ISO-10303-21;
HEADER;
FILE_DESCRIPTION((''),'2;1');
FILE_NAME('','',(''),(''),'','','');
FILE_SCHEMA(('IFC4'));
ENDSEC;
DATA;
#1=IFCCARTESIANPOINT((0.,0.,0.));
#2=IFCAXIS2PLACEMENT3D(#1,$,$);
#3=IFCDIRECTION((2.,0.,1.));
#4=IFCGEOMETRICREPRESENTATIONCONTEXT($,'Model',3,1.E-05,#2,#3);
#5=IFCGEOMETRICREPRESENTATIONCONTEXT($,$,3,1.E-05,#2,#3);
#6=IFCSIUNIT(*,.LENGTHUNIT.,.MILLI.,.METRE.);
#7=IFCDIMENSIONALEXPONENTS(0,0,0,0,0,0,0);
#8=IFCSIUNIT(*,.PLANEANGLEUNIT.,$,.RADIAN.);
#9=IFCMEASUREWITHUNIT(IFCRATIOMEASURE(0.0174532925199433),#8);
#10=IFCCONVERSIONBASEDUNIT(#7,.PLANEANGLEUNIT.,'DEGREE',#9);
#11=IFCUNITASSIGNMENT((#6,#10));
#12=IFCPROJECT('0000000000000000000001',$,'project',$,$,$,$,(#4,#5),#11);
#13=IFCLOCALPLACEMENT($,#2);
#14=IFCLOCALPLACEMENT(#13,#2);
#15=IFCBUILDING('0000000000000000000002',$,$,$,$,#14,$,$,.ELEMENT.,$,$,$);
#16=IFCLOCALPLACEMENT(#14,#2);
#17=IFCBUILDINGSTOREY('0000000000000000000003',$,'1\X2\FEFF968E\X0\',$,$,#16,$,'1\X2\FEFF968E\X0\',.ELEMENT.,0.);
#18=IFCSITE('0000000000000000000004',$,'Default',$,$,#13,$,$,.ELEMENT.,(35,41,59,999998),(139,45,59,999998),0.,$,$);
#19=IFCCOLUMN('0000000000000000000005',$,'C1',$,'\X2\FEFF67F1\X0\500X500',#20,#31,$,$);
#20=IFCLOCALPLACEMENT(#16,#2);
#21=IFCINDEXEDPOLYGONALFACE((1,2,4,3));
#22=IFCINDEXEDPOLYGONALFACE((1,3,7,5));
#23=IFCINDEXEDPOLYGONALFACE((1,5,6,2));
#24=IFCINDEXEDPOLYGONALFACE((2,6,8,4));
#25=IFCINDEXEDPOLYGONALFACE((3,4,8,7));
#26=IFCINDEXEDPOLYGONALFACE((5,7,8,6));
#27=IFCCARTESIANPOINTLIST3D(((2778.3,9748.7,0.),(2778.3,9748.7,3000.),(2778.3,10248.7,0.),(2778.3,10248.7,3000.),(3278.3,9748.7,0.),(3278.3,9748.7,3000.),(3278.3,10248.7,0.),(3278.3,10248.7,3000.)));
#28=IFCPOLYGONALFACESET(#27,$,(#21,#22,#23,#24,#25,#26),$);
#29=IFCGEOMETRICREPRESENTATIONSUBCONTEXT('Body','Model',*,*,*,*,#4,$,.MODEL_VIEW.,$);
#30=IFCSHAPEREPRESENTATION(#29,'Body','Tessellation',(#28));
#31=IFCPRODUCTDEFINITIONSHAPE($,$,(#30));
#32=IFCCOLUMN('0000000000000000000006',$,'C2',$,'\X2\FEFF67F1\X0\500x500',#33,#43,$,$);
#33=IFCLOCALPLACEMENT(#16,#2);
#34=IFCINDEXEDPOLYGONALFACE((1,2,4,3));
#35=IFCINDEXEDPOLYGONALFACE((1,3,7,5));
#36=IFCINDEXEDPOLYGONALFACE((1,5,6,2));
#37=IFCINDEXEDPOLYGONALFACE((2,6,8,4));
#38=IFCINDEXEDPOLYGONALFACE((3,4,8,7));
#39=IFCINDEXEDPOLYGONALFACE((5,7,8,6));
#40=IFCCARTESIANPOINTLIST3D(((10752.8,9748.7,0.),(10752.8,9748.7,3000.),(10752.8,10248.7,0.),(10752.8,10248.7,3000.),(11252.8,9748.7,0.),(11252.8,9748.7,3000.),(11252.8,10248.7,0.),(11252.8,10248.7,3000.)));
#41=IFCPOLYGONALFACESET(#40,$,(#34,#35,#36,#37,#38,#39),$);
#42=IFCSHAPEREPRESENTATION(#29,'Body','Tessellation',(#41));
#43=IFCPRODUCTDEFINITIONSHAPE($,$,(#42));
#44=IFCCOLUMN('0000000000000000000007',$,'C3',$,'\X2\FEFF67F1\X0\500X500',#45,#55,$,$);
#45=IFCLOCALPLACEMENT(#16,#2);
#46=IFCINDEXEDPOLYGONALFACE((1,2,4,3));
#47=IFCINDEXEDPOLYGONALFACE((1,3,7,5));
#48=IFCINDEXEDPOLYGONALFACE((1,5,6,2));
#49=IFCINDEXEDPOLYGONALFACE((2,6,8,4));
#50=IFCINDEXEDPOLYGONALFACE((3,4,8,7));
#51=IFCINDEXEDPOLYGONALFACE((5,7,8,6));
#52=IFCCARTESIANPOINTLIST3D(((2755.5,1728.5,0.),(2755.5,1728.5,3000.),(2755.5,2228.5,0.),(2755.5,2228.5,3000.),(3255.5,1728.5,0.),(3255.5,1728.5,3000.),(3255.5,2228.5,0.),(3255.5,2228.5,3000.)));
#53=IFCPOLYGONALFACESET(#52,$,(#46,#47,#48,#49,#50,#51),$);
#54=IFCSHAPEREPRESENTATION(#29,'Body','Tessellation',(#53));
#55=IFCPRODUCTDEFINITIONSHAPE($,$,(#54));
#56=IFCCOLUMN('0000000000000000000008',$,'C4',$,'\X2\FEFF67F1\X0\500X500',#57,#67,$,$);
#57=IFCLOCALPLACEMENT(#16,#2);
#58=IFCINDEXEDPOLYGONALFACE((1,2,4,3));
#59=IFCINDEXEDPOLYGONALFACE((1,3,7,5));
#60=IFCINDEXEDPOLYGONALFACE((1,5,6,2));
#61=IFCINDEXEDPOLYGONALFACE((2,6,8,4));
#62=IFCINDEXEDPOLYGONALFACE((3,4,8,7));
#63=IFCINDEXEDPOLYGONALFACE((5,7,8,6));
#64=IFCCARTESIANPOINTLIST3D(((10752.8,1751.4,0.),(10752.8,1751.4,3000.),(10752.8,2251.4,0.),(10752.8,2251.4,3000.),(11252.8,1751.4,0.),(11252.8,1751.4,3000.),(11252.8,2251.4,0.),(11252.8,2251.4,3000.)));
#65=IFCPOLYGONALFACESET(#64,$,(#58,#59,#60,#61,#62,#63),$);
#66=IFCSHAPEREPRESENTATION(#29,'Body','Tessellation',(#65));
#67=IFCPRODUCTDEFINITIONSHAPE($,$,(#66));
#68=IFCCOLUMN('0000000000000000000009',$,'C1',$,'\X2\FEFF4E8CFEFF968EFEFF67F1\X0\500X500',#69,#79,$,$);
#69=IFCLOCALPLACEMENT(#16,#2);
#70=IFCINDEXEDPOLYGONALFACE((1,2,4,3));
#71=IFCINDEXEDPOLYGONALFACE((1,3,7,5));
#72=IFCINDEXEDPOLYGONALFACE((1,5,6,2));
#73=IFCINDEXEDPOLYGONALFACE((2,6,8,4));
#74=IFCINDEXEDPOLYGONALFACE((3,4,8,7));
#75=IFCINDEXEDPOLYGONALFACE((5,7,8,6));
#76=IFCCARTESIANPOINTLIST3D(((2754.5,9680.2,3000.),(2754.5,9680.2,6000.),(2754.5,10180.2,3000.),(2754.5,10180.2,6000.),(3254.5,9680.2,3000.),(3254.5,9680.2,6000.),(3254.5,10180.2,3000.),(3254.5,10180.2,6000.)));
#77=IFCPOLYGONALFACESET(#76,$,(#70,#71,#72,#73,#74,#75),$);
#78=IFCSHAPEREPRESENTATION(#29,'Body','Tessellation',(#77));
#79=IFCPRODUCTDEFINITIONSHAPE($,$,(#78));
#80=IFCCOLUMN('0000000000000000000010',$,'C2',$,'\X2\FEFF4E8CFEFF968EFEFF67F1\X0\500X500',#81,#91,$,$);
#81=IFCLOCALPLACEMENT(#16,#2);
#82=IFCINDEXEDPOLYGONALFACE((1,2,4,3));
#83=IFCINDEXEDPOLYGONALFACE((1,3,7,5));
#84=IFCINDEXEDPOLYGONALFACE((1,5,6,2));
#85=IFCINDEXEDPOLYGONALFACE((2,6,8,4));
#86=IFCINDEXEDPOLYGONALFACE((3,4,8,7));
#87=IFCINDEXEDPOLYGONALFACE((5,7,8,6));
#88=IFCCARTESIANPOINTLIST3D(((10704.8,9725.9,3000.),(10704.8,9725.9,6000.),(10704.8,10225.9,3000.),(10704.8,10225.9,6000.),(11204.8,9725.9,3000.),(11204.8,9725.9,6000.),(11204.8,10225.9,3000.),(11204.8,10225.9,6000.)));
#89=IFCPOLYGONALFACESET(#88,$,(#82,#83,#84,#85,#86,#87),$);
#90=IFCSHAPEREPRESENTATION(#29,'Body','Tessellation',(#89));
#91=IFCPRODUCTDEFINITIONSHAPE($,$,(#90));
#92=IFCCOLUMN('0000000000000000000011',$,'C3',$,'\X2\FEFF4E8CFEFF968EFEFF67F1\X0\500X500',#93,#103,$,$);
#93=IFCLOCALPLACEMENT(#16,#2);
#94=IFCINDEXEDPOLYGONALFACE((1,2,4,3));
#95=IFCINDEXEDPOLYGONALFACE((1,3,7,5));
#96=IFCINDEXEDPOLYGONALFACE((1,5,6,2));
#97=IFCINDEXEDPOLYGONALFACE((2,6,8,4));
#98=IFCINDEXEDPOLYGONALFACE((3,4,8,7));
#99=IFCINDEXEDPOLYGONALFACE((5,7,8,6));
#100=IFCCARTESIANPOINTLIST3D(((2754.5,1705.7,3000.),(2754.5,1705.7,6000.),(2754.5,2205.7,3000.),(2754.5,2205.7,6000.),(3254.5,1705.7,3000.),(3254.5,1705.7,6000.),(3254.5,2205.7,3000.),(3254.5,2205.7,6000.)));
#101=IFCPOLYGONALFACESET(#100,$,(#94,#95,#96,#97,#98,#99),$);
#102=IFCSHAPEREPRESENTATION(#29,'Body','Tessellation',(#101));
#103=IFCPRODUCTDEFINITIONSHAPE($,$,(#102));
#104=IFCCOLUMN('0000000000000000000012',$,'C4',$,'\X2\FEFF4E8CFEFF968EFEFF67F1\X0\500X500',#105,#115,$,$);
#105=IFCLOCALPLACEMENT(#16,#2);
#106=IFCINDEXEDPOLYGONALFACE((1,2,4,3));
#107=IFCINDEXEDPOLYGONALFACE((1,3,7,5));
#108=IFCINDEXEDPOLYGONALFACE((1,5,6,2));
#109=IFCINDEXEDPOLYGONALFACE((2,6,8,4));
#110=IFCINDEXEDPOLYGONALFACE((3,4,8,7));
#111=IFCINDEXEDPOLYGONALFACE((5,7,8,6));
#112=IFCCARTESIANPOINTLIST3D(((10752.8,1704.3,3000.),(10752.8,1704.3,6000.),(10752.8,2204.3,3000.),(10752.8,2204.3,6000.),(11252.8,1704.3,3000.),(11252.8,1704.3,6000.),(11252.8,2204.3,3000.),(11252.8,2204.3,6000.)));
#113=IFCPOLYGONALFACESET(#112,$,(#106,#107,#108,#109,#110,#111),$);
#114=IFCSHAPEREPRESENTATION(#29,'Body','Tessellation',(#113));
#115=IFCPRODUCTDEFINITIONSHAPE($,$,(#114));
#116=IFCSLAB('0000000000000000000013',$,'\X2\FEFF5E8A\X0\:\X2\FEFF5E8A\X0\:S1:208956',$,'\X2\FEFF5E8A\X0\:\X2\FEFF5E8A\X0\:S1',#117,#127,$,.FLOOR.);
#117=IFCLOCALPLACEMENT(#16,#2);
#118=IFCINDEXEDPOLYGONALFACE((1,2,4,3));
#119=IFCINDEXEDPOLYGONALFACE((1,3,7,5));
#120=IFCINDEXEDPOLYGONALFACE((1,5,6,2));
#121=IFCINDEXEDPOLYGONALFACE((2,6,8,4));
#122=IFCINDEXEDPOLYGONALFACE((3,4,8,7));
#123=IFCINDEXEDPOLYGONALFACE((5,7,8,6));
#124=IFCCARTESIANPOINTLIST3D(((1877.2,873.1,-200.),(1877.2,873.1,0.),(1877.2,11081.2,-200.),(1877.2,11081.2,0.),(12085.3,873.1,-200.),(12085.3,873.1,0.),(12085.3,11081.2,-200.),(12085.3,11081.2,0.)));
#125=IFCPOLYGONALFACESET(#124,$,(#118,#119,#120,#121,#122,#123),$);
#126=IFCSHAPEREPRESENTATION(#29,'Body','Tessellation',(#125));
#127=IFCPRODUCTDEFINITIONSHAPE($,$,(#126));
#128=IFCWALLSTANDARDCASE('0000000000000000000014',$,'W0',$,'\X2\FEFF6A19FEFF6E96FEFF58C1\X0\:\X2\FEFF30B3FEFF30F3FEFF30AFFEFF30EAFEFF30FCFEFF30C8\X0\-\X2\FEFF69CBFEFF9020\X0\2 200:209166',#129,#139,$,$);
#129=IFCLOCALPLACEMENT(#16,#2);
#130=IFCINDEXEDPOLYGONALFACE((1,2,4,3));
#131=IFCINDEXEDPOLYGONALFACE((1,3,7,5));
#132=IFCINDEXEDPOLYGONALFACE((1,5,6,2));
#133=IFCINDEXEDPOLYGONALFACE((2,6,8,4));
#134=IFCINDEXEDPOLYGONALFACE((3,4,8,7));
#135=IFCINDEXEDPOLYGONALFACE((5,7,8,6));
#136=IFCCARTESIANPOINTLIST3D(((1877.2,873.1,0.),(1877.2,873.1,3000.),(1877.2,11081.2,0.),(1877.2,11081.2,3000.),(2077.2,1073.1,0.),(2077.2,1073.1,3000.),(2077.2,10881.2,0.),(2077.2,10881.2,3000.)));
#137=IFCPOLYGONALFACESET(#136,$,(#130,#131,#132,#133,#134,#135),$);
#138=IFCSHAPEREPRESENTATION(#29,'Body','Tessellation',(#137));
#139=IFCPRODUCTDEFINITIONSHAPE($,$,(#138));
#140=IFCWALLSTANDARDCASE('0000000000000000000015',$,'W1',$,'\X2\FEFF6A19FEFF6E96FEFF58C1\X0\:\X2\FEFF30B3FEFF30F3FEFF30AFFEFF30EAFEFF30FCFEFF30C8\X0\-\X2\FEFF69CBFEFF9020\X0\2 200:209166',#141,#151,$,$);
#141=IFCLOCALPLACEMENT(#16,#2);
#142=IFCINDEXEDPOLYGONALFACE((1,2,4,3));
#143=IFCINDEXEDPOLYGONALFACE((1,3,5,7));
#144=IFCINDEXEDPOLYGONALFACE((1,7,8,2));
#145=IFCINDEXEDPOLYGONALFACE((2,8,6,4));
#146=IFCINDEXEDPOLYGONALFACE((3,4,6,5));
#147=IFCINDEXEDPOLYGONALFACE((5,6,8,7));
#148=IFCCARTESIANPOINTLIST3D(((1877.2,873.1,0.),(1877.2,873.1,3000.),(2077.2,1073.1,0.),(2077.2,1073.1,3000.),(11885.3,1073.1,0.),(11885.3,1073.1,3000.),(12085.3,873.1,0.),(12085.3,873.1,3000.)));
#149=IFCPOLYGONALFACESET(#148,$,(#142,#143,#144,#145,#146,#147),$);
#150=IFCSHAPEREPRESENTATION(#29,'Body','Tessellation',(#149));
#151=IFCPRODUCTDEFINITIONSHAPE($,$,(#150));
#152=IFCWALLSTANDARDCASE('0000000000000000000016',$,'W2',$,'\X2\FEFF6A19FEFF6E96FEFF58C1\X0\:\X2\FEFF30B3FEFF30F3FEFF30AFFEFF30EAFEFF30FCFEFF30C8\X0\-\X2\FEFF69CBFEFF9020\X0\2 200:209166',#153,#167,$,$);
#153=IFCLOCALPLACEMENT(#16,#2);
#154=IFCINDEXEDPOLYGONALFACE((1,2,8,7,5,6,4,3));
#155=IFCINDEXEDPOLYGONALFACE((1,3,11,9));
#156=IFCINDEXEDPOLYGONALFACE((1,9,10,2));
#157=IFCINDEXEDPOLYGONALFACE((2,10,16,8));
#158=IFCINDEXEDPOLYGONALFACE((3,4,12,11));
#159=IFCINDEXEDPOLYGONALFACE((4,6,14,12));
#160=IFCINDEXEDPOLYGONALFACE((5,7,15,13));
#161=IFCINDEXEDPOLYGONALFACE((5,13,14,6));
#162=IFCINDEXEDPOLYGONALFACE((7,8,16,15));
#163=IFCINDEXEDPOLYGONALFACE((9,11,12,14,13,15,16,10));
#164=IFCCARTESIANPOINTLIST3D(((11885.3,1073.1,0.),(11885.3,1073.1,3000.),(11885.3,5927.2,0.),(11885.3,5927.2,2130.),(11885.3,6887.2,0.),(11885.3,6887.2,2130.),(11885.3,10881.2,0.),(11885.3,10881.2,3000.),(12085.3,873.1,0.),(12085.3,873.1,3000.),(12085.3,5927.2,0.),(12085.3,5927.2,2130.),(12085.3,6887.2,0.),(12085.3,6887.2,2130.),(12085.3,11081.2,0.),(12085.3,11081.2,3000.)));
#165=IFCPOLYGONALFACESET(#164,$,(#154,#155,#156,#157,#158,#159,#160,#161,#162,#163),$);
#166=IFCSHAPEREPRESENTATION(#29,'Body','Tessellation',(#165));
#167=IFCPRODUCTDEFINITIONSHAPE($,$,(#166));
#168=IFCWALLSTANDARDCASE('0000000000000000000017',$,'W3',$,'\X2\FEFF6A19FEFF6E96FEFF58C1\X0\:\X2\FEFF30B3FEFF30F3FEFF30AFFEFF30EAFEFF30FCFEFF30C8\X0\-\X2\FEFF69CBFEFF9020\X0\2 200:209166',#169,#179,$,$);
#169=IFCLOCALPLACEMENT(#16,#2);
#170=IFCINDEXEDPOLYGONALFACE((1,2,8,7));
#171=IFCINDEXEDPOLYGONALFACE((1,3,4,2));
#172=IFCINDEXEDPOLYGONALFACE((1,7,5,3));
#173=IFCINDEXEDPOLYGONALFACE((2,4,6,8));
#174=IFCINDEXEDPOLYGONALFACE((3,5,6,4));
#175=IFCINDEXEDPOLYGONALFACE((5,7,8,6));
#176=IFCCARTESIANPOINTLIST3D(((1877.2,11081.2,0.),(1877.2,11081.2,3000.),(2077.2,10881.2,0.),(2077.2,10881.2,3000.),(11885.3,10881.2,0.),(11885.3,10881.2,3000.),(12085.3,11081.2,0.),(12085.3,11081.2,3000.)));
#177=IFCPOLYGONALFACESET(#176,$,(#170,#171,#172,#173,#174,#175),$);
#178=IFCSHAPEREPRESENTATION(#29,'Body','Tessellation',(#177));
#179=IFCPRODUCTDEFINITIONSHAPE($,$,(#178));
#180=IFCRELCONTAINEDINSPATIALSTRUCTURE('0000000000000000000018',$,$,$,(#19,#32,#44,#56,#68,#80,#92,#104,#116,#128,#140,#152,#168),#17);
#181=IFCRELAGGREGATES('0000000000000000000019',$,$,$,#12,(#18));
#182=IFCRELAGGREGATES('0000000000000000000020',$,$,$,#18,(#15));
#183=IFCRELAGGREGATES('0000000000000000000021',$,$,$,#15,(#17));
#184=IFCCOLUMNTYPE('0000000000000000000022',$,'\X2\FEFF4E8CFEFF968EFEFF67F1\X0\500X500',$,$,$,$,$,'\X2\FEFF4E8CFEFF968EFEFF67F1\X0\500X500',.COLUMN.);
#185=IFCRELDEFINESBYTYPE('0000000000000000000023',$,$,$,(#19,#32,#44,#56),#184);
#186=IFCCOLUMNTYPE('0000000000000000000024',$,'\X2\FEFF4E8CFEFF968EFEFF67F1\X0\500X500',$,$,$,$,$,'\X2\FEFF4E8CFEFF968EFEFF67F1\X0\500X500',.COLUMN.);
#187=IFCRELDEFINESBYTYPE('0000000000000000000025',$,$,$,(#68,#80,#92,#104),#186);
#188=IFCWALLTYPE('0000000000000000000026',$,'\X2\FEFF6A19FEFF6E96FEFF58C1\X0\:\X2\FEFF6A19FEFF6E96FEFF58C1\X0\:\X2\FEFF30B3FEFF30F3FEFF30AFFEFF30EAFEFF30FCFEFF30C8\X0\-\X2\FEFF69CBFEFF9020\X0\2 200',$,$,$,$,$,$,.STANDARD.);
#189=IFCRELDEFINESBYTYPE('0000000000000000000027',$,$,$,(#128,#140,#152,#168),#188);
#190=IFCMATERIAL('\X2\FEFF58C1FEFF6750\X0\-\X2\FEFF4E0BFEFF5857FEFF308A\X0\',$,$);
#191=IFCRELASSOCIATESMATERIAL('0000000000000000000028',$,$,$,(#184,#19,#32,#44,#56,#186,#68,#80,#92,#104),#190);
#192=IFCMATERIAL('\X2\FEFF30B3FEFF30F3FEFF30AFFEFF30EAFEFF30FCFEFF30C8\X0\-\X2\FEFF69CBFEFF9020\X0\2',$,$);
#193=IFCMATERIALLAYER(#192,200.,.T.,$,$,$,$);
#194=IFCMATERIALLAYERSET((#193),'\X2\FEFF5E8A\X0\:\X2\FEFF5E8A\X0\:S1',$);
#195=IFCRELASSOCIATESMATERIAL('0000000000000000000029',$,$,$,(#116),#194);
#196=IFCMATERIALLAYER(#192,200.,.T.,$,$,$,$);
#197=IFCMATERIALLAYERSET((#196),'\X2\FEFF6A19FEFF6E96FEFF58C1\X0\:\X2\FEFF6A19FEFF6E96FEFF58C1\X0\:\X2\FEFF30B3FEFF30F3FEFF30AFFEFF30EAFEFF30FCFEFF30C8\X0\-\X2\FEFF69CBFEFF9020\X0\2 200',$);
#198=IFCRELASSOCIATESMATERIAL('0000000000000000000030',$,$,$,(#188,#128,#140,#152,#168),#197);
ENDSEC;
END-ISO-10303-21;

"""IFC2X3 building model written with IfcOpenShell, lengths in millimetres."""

from ifc_helpers import new_model, entity, si_unit, converted_unit, direction, frame, frame_2d, origin, origin_2d_with_axis, place, context, subcontext, project, spatial, polyline, rectangle, outline, extrude, source, transform, mapped, material, layer, layer_set, layer_usage, type_object, type_shapes, element, save


model = new_model("IFC2X3")

# Units and contexts
model_context = context("Model", 3, precision=1e-05, world=origin(), true_north=direction((2.0, 0.0, 1.0)))
context_of_model = context(None, 3, precision=1e-05, world=origin(), true_north=direction((2.0, 0.0, 1.0)))
body_context = subcontext(model_context, "Body", "Model", "MODEL_VIEW")
ifc_project = project(units=[si_unit("LENGTHUNIT", "METRE", prefix="MILLI"), converted_unit("PLANEANGLEUNIT", "DEGREE", entity("IfcRatioMeasure", 0.0174532925199433), si_unit("PLANEANGLEUNIT", "RADIAN"), dimensions=[0, 0, 0, 0, 0, 0, 0])], contexts=[model_context, context_of_model])

# Site, building, storey
site_placement = place(None, origin())
site = spatial("IfcSite", under=ifc_project, at=site_placement, Name="Default", CompositionType="ELEMENT", RefLatitude=(35, 41, 59, 999998), RefLongitude=(139, 45, 59, 999998), RefElevation=0.0)
building_placement = place(site_placement, origin())
building = spatial("IfcBuilding", under=site, at=building_placement, CompositionType="ELEMENT")
storey_placement = place(building_placement, origin())
storey = spatial("IfcBuildingStorey", under=building, at=storey_placement, Name="1\ufeff階", LongName="1\ufeff階", CompositionType="ELEMENT", Elevation=0.0)

# Columns
ifc_material_1 = material(Name="\ufeff壁\ufeff材-\ufeff下\ufeff塗\ufeffり")
column_type_1 = type_object("IfcColumnType", Name="\ufeff二\ufeff階\ufeff柱500X500", ElementType="\ufeff二\ufeff階\ufeff柱500X500", PredefinedType="COLUMN", material=ifc_material_1)
shared_shape_1 = source(origin(), body_context, "Body", "SweptSolid", [
    extrude(rectangle(XDim=500.0, YDim=500.0, at=origin_2d_with_axis()), origin(), (0.0, 0.0, 1.0), 3000.0),
])
type_shapes(column_type_1, [shared_shape_1])
column_1_placement = place(storey_placement, frame((3028.3, 9998.7, 0.0)))
element("IfcColumn", 1, at=column_1_placement, inside=storey, type_object=column_type_1, material=ifc_material_1, Name="C1", ObjectType="\ufeff柱500X500", context=body_context, shape_type="MappedRepresentation", body=[
    mapped(shared_shape_1, transform((0.0, 0.0, 0.0), scale=1.0)),
])
column_2_placement = place(storey_placement, frame((11002.8, 9998.7, 0.0)))
element("IfcColumn", 2, at=column_2_placement, inside=storey, type_object=column_type_1, material=ifc_material_1, Name="C2", ObjectType="\ufeff柱500x500", context=body_context, shape_type="MappedRepresentation", body=[
    mapped(shared_shape_1, transform((0.0, 0.0, 0.0), scale=1.0)),
])
for number, where, name in (
    (3, (3005.5, 1978.5, 0.0), "C3"),
    (4, (11002.8, 2001.4, 0.0), "C4"),
):
    element("IfcColumn", number, at=place(storey_placement, frame(where)), inside=storey, type_object=column_type_1, material=ifc_material_1, Name=name, ObjectType="\ufeff柱500X500", context=body_context, shape_type="MappedRepresentation", body=[
        mapped(shared_shape_1, transform((0.0, 0.0, 0.0), scale=1.0)),
    ])
column_type_2 = type_object("IfcColumnType", Name="\ufeff二\ufeff階\ufeff柱500X500", ElementType="\ufeff二\ufeff階\ufeff柱500X500", PredefinedType="COLUMN", material=ifc_material_1)
shared_shape_2 = source(origin(), body_context, "Body", "SweptSolid", [
    extrude(rectangle(XDim=500.0, YDim=500.0, at=origin_2d_with_axis()), origin(), (0.0, 0.0, 1.0), 3000.0),
])
type_shapes(column_type_2, [shared_shape_2])
for number, where, name in (
    (5, (3004.5, 9930.2, 3000.0), "C1"),
    (6, (10954.8, 9975.9, 3000.0), "C2"),
    (7, (3004.5, 1955.7, 3000.0), "C3"),
    (8, (11002.8, 1954.3, 3000.0), "C4"),
):
    element("IfcColumn", number, at=place(storey_placement, frame(where)), inside=storey, type_object=column_type_2, material=ifc_material_1, Name=name, ObjectType="\ufeff二\ufeff階\ufeff柱500X500", context=body_context, shape_type="MappedRepresentation", body=[
        mapped(shared_shape_2, transform((0.0, 0.0, 0.0), scale=1.0)),
    ])

# Slab
ifc_material_2 = material(Name="\ufeffコ\ufeffン\ufeffク\ufeffリ\ufeffー\ufeffト-\ufeff構\ufeff造2")
ifc_layer_1 = layer(ifc_material_2, 200.0, ventilated=True)
ifc_layer_set_1 = layer_set([ifc_layer_1], Name="\ufeff床:\ufeff床:S1")
ifc_layer_usage_1 = layer_usage(ifc_layer_set_1, "AXIS3", "POSITIVE", 0.0)
slab_placement = place(storey_placement, origin())
element("IfcSlab", 9, at=slab_placement, inside=storey, material=ifc_layer_usage_1, Name="\ufeff床:\ufeff床:S1:208956", ObjectType="\ufeff床:\ufeff床:S1", PredefinedType="FLOOR", context=body_context, shape_type="SweptSolid", body=[
    extrude(rectangle(XDim=10208.1, YDim=10208.1, at=origin_2d_with_axis()), frame((6981.3, 5977.2, 0.0), z_axis=(0.0, 0.0, -1.0), x_axis=(0.0, 1.0, 0.0)), (0.0, 0.0, 1.0), 200.0),
])

# Walls
ifc_layer_2 = layer(ifc_material_2, 200.0, ventilated=True)
ifc_layer_set_2 = layer_set([ifc_layer_2], Name="\ufeff標\ufeff準\ufeff壁:\ufeff標\ufeff準\ufeff壁:\ufeffコ\ufeffン\ufeffク\ufeffリ\ufeffー\ufeffト-\ufeff構\ufeff造2 200")
ifc_layer_usage_2 = layer_usage(ifc_layer_set_2, "AXIS2", "NEGATIVE", 100.0)
wall_type = type_object("IfcWallType", Name="\ufeff標\ufeff準\ufeff壁:\ufeff標\ufeff準\ufeff壁:\ufeffコ\ufeffン\ufeffク\ufeffリ\ufeffー\ufeffト-\ufeff構\ufeff造2 200", PredefinedType="STANDARD", material=ifc_layer_set_2)
wall_1_placement = place(storey_placement, frame((1977.2, 11081.2, 0.0), z_axis=(0.0, 0.0, 1.0), x_axis=(0.0, -1.0, 0.0)))
element("IfcWallStandardCase", 10, at=wall_1_placement, inside=storey, type_object=wall_type, material=ifc_layer_usage_2, Name="W0", ObjectType="\ufeff標\ufeff準\ufeff壁:\ufeffコ\ufeffン\ufeffク\ufeffリ\ufeffー\ufeffト-\ufeff構\ufeff造2 200:209166", context=body_context, shape_type="SweptSolid", body=[
    extrude(outline(polyline([(10208.1, -100.0), (10008.1, 100.0), (200.0, 100.0), (0.0, -100.0), (10208.1, -100.0)])), origin(), (0.0, 0.0, 1.0), 3000.0),
])
ifc_layer_usage_3 = layer_usage(ifc_layer_set_2, "AXIS2", "NEGATIVE", 100.0)
wall_2_placement = place(storey_placement, frame((1877.2, 973.1, 0.0)))
element("IfcWallStandardCase", 11, at=wall_2_placement, inside=storey, type_object=wall_type, material=ifc_layer_usage_3, Name="W1", ObjectType="\ufeff標\ufeff準\ufeff壁:\ufeffコ\ufeffン\ufeffク\ufeffリ\ufeffー\ufeffト-\ufeff構\ufeff造2 200:209166", context=body_context, shape_type="SweptSolid", body=[
    extrude(outline(polyline([(10208.1, -100.0), (10008.1, 100.0), (200.0, 100.0), (0.0, -100.0), (10208.1, -100.0)])), origin(), (0.0, 0.0, 1.0), 3000.0),
])

# Wall, opening
ifc_layer_usage_4 = layer_usage(ifc_layer_set_2, "AXIS2", "NEGATIVE", 100.0)
wall_3_placement = place(storey_placement, frame((11985.3, 873.1, 0.0), z_axis=(0.0, 0.0, 1.0), x_axis=(0.0, 1.0, 0.0)))
wall_3 = element("IfcWallStandardCase", 12, at=wall_3_placement, inside=storey, type_object=wall_type, material=ifc_layer_usage_4, Name="W2", ObjectType="\ufeff標\ufeff準\ufeff壁:\ufeffコ\ufeffン\ufeffク\ufeffリ\ufeffー\ufeffト-\ufeff構\ufeff造2 200:209166", context=body_context, shape_type="SweptSolid", body=[
    extrude(outline(polyline([(0.0, -100.0), (10208.1, -100.0), (10008.1, 100.0), (200.0, 100.0), (0.0, -100.0)])), origin(), (0.0, 0.0, 1.0), 3000.0),
])
opening_placement = place(wall_3_placement, origin())
element("IfcOpeningElement", 13, at=opening_placement, cuts=wall_3, ObjectType="Opening", context=body_context, shape_type="SweptSolid", body=[
    extrude(rectangle(XDim=2130.0, YDim=960.0, at=frame_2d((0.0, 0.0), x_axis=(0.0, 1.0))), frame((5534.1, -208.1, 1065.0), z_axis=(0.0, 1.0, 0.0), x_axis=(-1.0, 0.0, 0.0)), (0.0, 0.0, 1.0), 416.2),
])

# Wall
ifc_layer_usage_5 = layer_usage(ifc_layer_set_2, "AXIS2", "NEGATIVE", 100.0)
wall_4_placement = place(storey_placement, frame((12085.3, 10981.2, 0.0), z_axis=(0.0, 0.0, 1.0), x_axis=(-1.0, 0.0, 0.0)))
element("IfcWallStandardCase", 14, at=wall_4_placement, inside=storey, type_object=wall_type, material=ifc_layer_usage_5, Name="W3", ObjectType="\ufeff標\ufeff準\ufeff壁:\ufeffコ\ufeffン\ufeffク\ufeffリ\ufeffー\ufeffト-\ufeff構\ufeff造2 200:209166", context=body_context, shape_type="SweptSolid", body=[
    extrude(outline(polyline([(10208.1, -100.0), (10008.1, 100.0), (200.0, 100.0), (0.0, -100.0), (10208.1, -100.0)])), origin(), (0.0, 0.0, 1.0), 3000.0),
])

save(model, "model.ifc")
